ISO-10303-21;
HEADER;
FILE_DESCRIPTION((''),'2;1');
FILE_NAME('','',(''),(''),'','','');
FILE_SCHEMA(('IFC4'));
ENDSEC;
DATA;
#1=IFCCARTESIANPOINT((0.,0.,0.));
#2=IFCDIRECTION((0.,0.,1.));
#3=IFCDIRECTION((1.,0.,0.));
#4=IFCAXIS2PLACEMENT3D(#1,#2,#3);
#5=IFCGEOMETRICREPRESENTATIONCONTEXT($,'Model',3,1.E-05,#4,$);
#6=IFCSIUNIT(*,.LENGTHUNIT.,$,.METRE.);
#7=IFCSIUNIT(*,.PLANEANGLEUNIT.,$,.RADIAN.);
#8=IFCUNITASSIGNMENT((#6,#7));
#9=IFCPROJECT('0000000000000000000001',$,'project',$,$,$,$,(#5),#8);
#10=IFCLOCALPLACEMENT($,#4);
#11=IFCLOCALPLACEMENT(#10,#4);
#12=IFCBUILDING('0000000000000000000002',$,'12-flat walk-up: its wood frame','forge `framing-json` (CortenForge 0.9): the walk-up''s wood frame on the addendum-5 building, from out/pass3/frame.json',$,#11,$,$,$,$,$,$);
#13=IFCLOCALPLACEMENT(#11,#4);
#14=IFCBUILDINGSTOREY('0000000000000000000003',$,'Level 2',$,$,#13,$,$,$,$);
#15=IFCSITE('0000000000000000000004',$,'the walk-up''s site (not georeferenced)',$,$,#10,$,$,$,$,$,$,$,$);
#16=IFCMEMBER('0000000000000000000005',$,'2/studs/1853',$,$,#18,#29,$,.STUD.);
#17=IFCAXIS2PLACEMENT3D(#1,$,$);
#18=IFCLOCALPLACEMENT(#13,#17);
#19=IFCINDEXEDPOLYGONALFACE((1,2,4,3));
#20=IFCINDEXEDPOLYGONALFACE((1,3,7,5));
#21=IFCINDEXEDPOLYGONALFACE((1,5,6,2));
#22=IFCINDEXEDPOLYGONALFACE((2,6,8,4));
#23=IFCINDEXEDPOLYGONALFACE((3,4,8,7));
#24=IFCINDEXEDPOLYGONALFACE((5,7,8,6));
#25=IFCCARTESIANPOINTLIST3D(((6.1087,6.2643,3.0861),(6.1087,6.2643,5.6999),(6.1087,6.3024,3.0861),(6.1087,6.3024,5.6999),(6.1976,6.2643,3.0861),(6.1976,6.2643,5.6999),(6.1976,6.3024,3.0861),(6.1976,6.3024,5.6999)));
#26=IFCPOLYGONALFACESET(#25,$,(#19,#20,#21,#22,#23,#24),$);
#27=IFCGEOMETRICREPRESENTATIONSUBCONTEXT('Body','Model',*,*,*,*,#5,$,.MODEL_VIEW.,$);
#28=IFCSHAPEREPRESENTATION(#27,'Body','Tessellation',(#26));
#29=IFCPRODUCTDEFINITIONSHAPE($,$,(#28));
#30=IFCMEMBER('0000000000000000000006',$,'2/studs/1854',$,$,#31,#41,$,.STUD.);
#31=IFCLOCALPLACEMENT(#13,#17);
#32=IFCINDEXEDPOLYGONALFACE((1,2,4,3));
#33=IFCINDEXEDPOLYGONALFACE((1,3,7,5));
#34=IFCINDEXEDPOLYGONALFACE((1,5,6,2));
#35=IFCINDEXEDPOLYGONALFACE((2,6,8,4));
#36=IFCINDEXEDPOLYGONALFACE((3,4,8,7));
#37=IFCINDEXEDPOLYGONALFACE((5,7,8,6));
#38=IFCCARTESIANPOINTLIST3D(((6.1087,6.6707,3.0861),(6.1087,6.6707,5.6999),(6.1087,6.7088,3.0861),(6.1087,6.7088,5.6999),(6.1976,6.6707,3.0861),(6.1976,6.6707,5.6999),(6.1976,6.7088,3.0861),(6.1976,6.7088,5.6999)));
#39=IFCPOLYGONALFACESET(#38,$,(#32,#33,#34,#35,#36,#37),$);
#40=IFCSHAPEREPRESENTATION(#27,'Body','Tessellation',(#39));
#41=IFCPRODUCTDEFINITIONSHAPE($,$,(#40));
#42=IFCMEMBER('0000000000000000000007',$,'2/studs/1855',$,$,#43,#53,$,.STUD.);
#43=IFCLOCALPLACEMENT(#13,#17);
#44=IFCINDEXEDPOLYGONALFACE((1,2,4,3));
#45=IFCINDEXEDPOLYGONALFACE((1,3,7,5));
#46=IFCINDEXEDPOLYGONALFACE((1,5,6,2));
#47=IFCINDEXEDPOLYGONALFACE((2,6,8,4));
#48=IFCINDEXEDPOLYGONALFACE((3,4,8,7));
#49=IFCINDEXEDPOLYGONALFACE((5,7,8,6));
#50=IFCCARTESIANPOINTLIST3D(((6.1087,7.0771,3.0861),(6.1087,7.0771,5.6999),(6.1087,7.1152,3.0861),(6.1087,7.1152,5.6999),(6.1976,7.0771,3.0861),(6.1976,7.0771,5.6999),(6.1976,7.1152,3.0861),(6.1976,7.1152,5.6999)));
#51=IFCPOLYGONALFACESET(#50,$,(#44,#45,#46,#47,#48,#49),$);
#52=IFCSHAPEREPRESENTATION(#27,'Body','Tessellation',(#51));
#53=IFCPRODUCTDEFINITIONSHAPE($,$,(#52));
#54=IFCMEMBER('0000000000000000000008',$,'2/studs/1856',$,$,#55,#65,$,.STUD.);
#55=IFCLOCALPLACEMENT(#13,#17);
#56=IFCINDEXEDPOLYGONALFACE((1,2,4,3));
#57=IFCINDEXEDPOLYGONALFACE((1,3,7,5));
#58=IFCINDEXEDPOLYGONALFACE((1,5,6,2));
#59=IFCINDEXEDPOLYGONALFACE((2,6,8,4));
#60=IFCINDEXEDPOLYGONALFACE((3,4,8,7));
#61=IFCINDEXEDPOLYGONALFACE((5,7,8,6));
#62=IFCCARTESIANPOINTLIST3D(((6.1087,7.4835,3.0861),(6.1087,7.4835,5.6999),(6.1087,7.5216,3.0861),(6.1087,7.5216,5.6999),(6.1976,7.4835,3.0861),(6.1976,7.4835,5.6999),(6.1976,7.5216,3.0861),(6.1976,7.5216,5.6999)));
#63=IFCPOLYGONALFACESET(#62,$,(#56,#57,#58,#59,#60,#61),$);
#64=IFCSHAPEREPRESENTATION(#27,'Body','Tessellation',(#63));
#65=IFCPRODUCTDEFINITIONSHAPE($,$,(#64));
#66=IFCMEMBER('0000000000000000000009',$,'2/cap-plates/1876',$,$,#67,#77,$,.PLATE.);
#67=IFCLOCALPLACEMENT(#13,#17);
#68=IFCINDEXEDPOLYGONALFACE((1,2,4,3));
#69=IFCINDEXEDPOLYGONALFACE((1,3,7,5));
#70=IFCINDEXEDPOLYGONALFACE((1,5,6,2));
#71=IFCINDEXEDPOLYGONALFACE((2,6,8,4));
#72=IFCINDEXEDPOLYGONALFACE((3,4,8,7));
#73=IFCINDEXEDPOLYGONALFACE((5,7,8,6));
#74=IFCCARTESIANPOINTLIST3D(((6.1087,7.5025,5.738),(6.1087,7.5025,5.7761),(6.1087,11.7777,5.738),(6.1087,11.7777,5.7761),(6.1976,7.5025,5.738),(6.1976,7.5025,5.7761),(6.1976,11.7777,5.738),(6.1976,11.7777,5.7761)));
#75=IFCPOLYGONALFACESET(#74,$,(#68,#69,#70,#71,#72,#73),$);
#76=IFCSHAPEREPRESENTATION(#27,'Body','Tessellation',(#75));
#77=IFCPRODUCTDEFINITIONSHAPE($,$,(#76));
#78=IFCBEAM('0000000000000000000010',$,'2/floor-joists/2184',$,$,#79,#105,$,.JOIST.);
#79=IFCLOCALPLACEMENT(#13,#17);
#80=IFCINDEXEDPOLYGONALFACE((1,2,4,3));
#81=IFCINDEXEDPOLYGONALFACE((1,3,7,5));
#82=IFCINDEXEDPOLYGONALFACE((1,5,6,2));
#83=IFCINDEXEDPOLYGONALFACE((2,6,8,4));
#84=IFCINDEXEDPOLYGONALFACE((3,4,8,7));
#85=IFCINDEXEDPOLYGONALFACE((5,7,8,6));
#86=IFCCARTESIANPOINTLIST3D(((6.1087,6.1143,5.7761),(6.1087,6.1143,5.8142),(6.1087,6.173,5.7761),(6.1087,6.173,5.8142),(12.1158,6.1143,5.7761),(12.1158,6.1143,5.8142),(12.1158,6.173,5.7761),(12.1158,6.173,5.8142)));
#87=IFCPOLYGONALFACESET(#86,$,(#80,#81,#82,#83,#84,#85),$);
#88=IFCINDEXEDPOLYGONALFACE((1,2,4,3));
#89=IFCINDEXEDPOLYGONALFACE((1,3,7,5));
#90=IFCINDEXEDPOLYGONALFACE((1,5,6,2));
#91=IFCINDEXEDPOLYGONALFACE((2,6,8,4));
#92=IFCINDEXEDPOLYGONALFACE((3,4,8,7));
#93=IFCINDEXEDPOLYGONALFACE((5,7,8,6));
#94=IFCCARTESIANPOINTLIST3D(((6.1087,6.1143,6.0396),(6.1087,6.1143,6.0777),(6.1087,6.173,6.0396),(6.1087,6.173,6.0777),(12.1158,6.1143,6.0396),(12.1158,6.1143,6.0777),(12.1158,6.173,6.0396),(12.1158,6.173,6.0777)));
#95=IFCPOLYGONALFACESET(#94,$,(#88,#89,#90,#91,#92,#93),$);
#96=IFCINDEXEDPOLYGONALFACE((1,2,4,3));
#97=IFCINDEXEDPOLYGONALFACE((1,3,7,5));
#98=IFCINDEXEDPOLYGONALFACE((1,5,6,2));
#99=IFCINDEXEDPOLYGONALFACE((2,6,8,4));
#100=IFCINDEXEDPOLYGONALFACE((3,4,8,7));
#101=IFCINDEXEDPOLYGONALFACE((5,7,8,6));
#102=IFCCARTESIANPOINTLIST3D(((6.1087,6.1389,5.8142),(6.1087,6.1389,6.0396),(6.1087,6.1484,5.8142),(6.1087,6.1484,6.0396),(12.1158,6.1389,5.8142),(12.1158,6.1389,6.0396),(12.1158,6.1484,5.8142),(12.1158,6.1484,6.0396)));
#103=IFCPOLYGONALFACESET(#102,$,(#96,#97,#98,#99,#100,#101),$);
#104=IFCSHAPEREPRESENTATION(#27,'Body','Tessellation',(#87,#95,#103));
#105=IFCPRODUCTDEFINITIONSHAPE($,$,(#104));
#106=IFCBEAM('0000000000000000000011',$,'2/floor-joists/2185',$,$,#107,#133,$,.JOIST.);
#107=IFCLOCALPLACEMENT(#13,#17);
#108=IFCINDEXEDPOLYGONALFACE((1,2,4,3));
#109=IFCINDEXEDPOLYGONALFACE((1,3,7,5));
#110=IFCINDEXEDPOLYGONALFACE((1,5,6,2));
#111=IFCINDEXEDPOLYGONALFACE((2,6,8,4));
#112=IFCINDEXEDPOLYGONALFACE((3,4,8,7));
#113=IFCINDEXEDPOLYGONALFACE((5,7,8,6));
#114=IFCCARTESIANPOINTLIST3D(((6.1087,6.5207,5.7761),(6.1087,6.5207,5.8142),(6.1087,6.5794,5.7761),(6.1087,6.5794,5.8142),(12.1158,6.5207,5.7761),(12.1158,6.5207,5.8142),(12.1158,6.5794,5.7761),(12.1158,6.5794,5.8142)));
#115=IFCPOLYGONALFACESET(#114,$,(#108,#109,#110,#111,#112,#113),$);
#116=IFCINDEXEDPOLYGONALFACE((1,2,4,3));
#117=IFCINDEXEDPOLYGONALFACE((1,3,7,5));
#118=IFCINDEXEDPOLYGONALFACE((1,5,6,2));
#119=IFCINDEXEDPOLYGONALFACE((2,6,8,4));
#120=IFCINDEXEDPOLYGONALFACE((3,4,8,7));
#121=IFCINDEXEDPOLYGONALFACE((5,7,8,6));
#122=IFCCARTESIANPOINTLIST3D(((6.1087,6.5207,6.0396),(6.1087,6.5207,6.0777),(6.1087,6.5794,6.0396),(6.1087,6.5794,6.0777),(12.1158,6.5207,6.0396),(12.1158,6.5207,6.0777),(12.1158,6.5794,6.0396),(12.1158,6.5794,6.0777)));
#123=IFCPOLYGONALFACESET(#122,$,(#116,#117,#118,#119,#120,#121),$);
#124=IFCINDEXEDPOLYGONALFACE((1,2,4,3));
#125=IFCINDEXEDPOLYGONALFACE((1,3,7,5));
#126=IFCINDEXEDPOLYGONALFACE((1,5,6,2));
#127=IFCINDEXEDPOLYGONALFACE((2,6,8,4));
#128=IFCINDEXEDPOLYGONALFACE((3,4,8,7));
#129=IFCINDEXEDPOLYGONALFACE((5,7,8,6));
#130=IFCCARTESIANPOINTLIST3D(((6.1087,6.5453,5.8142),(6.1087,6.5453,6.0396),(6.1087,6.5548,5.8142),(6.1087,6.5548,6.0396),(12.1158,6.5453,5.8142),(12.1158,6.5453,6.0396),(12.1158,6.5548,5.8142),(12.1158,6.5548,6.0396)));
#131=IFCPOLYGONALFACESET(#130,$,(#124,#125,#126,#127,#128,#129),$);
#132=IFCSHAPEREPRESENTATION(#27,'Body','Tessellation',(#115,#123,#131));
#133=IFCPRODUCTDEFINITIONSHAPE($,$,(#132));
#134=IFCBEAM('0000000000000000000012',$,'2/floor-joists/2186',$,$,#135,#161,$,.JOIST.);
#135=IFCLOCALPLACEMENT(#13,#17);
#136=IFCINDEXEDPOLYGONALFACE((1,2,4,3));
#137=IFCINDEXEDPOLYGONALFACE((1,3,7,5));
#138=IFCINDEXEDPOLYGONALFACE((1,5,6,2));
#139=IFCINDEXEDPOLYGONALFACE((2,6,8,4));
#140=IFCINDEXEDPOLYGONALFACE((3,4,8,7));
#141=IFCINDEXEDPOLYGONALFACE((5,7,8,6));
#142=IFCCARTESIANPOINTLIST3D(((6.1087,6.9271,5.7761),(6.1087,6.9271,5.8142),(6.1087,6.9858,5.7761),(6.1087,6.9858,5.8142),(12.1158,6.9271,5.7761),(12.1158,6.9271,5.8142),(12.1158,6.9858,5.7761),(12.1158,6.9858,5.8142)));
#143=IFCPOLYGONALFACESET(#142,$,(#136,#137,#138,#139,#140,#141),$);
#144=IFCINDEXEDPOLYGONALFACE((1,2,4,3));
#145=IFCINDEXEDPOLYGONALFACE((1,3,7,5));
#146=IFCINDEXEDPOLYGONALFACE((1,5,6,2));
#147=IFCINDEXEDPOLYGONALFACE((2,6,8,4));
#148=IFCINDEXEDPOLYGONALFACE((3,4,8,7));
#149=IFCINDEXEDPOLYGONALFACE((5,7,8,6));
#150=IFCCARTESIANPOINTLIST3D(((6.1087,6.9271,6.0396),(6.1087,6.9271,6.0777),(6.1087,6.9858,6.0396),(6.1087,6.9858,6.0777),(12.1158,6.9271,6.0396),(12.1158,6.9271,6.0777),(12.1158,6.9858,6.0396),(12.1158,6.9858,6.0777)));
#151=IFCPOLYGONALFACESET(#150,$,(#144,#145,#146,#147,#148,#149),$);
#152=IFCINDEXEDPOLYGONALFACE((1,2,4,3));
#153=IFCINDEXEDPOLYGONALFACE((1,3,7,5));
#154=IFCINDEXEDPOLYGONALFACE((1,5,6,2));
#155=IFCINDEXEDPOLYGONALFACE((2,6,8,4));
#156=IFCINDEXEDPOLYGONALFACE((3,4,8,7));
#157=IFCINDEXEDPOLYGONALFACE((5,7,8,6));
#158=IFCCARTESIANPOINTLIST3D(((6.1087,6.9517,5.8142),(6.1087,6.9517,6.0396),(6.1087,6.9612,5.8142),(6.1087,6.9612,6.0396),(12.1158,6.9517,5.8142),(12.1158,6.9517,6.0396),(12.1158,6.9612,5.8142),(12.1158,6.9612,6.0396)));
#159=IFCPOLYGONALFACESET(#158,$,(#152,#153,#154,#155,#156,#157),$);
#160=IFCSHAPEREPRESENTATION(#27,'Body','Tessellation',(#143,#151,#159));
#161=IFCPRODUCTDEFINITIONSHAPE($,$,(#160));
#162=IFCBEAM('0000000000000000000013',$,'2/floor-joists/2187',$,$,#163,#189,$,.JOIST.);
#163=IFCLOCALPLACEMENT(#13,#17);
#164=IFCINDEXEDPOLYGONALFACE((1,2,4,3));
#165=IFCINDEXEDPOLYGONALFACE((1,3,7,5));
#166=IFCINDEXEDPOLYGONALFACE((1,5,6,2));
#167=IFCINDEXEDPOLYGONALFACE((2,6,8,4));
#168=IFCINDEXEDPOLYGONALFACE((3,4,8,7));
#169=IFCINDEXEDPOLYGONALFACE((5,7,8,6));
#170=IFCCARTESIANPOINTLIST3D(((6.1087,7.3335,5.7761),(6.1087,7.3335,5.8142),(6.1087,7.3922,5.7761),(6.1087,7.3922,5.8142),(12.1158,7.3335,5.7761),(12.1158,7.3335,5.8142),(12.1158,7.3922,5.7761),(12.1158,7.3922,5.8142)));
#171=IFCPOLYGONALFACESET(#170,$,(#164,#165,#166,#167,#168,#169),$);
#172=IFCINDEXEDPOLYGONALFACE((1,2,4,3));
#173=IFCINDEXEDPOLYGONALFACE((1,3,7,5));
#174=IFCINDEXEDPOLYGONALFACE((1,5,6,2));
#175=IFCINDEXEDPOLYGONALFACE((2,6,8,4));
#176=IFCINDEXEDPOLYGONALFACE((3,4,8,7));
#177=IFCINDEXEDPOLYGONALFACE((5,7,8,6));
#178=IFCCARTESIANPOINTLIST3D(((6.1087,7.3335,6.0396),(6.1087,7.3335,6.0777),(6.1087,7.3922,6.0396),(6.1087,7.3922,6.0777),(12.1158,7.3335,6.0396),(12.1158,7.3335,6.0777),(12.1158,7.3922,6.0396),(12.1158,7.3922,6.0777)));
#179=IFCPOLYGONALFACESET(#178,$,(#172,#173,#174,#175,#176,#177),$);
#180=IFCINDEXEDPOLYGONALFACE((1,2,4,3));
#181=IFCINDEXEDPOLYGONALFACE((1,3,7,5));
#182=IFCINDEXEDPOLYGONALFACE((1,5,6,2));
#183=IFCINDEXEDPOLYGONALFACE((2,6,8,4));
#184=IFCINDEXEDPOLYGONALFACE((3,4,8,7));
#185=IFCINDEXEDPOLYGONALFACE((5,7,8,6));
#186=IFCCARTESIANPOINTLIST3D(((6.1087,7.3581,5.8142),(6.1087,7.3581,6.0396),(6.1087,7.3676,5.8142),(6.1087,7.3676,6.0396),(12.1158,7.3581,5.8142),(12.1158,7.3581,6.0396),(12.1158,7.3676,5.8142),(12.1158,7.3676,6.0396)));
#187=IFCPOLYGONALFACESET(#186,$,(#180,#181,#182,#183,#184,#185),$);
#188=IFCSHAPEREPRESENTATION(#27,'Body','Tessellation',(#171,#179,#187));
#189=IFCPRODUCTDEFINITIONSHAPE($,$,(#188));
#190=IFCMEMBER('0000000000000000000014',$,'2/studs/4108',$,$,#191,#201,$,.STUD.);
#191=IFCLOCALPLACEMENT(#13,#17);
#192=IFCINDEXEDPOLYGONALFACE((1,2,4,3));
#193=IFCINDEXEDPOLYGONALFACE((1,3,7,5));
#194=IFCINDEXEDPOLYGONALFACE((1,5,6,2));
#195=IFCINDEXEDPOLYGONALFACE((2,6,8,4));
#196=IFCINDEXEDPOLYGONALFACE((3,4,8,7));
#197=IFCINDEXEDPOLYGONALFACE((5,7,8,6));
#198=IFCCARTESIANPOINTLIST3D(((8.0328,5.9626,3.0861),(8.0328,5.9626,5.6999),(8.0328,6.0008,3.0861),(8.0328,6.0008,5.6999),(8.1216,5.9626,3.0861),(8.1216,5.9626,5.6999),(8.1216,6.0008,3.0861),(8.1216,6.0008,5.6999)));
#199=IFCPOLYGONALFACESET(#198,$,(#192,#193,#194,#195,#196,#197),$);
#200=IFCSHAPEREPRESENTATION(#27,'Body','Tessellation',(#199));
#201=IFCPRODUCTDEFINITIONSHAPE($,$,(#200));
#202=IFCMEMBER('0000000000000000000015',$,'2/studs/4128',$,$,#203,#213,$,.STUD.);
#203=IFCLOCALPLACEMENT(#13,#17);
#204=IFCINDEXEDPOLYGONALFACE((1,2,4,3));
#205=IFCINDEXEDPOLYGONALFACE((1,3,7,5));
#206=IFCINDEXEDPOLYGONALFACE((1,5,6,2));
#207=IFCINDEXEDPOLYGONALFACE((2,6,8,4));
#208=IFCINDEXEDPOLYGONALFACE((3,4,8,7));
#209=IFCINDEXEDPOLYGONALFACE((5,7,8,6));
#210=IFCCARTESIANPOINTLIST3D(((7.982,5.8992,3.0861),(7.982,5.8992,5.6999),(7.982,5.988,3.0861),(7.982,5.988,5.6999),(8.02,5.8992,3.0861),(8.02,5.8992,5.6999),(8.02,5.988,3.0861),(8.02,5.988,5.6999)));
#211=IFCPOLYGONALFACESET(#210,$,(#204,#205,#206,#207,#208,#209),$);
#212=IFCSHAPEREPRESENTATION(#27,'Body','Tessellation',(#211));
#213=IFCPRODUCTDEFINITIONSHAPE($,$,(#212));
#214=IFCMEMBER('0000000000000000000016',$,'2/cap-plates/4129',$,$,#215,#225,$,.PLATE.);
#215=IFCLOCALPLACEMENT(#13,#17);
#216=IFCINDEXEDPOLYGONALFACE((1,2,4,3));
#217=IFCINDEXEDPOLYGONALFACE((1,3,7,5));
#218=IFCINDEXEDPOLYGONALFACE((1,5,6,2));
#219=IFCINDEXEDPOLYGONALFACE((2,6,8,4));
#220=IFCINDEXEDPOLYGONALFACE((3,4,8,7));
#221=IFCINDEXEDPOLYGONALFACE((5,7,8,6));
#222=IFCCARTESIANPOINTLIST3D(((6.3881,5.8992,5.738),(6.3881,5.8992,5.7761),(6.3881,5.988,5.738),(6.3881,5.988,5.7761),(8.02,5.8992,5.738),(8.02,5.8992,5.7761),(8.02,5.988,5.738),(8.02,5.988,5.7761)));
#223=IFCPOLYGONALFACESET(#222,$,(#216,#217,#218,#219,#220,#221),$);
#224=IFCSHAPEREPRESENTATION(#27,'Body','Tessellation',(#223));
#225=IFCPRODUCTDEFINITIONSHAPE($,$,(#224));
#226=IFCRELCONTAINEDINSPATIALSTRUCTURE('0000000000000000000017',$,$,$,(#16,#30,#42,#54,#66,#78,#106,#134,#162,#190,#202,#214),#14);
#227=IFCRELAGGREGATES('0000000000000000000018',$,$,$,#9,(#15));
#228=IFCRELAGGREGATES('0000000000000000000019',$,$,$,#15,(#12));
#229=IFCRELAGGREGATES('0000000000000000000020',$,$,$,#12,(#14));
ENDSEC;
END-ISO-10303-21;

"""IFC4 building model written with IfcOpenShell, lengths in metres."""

from ifc_helpers import new_model, si_unit, frame, frame_2d, origin, origin_with_axes, place, context, subcontext, project, spatial, rectangle, extrude, element, save


model = new_model("IFC4")

# Units and contexts
model_context = context("Model", 3, precision=1e-05, world=origin_with_axes())
body_context = subcontext(model_context, "Body", "Model", "MODEL_VIEW")
ifc_project = project(units=[si_unit("LENGTHUNIT", "METRE"), si_unit("PLANEANGLEUNIT", "RADIAN")], contexts=[model_context])

# Site, building, storey
site_placement = place(None, origin_with_axes())
site = spatial("IfcSite", under=ifc_project, at=site_placement, Name="the walk-up's site (not georeferenced)")
building_placement = place(site_placement, origin_with_axes())
building = spatial("IfcBuilding", under=site, at=building_placement, Name="12-flat walk-up: its wood frame", Description="forge `framing-json` (CortenForge 0.9): the walk-up's wood frame on the addendum-5 building, from out/pass3/frame.json")
storey_placement = place(building_placement, origin_with_axes())
storey = spatial("IfcBuildingStorey", under=building, at=storey_placement, Name="Level 2")

# Members
for number, where, z_axis, x_axis, name in (
    (1, (6.1087, 6.2643, 3.0861), (0.0, 0.0, 1.0), (1.0, 0.0, 0.0), "2/studs/1853"),
    (2, (6.1087, 6.6707, 3.0861), (0.0, 0.0, 1.0), (1.0, 0.0, 0.0), "2/studs/1854"),
    (3, (6.1087, 7.0771, 3.0861), (0.0, 0.0, 1.0), (1.0, 0.0, 0.0), "2/studs/1855"),
    (4, (6.1087, 7.4835, 3.0861), (0.0, 0.0, 1.0), (1.0, 0.0, 0.0), "2/studs/1856"),
):
    element("IfcMember", number, at=place(storey_placement, frame(where, z_axis=z_axis, x_axis=x_axis)), inside=storey, Name=name, PredefinedType="STUD", context=body_context, shape_type="SweptSolid", body=[
        extrude(rectangle(XDim=0.0889, YDim=0.0381, at=frame_2d((0.0445, 0.0191))), origin(), (0.0, 0.0, 1.0), 2.6138),
    ])
member_1_placement = place(storey_placement, frame((6.1087, 7.5025, 5.738), z_axis=(0.0, 0.0, 1.0), x_axis=(1.0, 0.0, 0.0)))
element("IfcMember", 5, at=member_1_placement, inside=storey, Name="2/cap-plates/1876", PredefinedType="PLATE", context=body_context, shape_type="SweptSolid", body=[
    extrude(rectangle(XDim=0.0889, YDim=4.2751, at=frame_2d((0.0445, 2.1376))), origin(), (0.0, 0.0, 1.0), 0.0381),
])

# Beams
beam_1_placement = place(storey_placement, frame((6.1087, 6.1143, 5.7761), z_axis=(0.0, 0.0, 1.0), x_axis=(1.0, 0.0, 0.0)))
element("IfcBeam", 6, at=beam_1_placement, inside=storey, Name="2/floor-joists/2184", PredefinedType="JOIST", context=body_context, shape_type="SweptSolid", body=[
    extrude(rectangle(XDim=6.0071, YDim=0.0587, at=frame_2d((3.0036, 0.0294))), origin(), (0.0, 0.0, 1.0), 0.0381),
    extrude(rectangle(XDim=6.0071, YDim=0.0587, at=frame_2d((3.0036, 0.0294))), frame((0.0, 0.0, 0.2635)), (0.0, 0.0, 1.0), 0.0381),
    extrude(rectangle(XDim=6.0071, YDim=0.0095, at=frame_2d((3.0036, 0.0048))), frame((0.0, 0.0246, 0.0381)), (0.0, 0.0, 1.0), 0.2254),
])
beam_2_placement = place(storey_placement, frame((6.1087, 6.5207, 5.7761), z_axis=(0.0, 0.0, 1.0), x_axis=(1.0, 0.0, 0.0)))
element("IfcBeam", 7, at=beam_2_placement, inside=storey, Name="2/floor-joists/2185", PredefinedType="JOIST", context=body_context, shape_type="SweptSolid", body=[
    extrude(rectangle(XDim=6.0071, YDim=0.0587, at=frame_2d((3.0036, 0.0294))), origin(), (0.0, 0.0, 1.0), 0.0381),
    extrude(rectangle(XDim=6.0071, YDim=0.0587, at=frame_2d((3.0036, 0.0294))), frame((0.0, 0.0, 0.2635)), (0.0, 0.0, 1.0), 0.0381),
    extrude(rectangle(XDim=6.0071, YDim=0.0095, at=frame_2d((3.0036, 0.0048))), frame((0.0, 0.0246, 0.0381)), (0.0, 0.0, 1.0), 0.2254),
])
beam_3_placement = place(storey_placement, frame((6.1087, 6.9271, 5.7761), z_axis=(0.0, 0.0, 1.0), x_axis=(1.0, 0.0, 0.0)))
element("IfcBeam", 8, at=beam_3_placement, inside=storey, Name="2/floor-joists/2186", PredefinedType="JOIST", context=body_context, shape_type="SweptSolid", body=[
    extrude(rectangle(XDim=6.0071, YDim=0.0587, at=frame_2d((3.0036, 0.0294))), origin(), (0.0, 0.0, 1.0), 0.0381),
    extrude(rectangle(XDim=6.0071, YDim=0.0587, at=frame_2d((3.0036, 0.0294))), frame((0.0, 0.0, 0.2635)), (0.0, 0.0, 1.0), 0.0381),
    extrude(rectangle(XDim=6.0071, YDim=0.0095, at=frame_2d((3.0036, 0.0048))), frame((0.0, 0.0246, 0.0381)), (0.0, 0.0, 1.0), 0.2254),
])
beam_4_placement = place(storey_placement, frame((6.1087, 7.3335, 5.7761), z_axis=(0.0, 0.0, 1.0), x_axis=(1.0, 0.0, 0.0)))
element("IfcBeam", 9, at=beam_4_placement, inside=storey, Name="2/floor-joists/2187", PredefinedType="JOIST", context=body_context, shape_type="SweptSolid", body=[
    extrude(rectangle(XDim=6.0071, YDim=0.0587, at=frame_2d((3.0036, 0.0294))), origin(), (0.0, 0.0, 1.0), 0.0381),
    extrude(rectangle(XDim=6.0071, YDim=0.0587, at=frame_2d((3.0036, 0.0294))), frame((0.0, 0.0, 0.2635)), (0.0, 0.0, 1.0), 0.0381),
    extrude(rectangle(XDim=6.0071, YDim=0.0095, at=frame_2d((3.0036, 0.0048))), frame((0.0, 0.0246, 0.0381)), (0.0, 0.0, 1.0), 0.2254),
])

# Members
member_2_placement = place(storey_placement, frame((8.0328, 5.9627, 3.0861), z_axis=(0.0, 0.0, 1.0), x_axis=(1.0, 0.0, 0.0)))
element("IfcMember", 10, at=member_2_placement, inside=storey, Name="2/studs/4108", PredefinedType="STUD", context=body_context, shape_type="SweptSolid", body=[
    extrude(rectangle(XDim=0.0889, YDim=0.0381, at=frame_2d((0.0445, 0.0191))), origin(), (0.0, 0.0, 1.0), 2.6138),
])
member_3_placement = place(storey_placement, frame((7.982, 5.8991, 3.0861), z_axis=(0.0, 0.0, 1.0), x_axis=(1.0, 0.0, 0.0)))
element("IfcMember", 11, at=member_3_placement, inside=storey, Name="2/studs/4128", PredefinedType="STUD", context=body_context, shape_type="SweptSolid", body=[
    extrude(rectangle(XDim=0.0381, YDim=0.0889, at=frame_2d((0.019, 0.0445))), origin(), (0.0, 0.0, 1.0), 2.6138),
])
member_4_placement = place(storey_placement, frame((6.3881, 5.8991, 5.738), z_axis=(0.0, 0.0, 1.0), x_axis=(1.0, 0.0, 0.0)))
element("IfcMember", 12, at=member_4_placement, inside=storey, Name="2/cap-plates/4129", PredefinedType="PLATE", context=body_context, shape_type="SweptSolid", body=[
    extrude(rectangle(XDim=1.6319, YDim=0.0889, at=frame_2d((0.816, 0.0445))), origin(), (0.0, 0.0, 1.0), 0.0381),
])

save(model, "model.ifc")
